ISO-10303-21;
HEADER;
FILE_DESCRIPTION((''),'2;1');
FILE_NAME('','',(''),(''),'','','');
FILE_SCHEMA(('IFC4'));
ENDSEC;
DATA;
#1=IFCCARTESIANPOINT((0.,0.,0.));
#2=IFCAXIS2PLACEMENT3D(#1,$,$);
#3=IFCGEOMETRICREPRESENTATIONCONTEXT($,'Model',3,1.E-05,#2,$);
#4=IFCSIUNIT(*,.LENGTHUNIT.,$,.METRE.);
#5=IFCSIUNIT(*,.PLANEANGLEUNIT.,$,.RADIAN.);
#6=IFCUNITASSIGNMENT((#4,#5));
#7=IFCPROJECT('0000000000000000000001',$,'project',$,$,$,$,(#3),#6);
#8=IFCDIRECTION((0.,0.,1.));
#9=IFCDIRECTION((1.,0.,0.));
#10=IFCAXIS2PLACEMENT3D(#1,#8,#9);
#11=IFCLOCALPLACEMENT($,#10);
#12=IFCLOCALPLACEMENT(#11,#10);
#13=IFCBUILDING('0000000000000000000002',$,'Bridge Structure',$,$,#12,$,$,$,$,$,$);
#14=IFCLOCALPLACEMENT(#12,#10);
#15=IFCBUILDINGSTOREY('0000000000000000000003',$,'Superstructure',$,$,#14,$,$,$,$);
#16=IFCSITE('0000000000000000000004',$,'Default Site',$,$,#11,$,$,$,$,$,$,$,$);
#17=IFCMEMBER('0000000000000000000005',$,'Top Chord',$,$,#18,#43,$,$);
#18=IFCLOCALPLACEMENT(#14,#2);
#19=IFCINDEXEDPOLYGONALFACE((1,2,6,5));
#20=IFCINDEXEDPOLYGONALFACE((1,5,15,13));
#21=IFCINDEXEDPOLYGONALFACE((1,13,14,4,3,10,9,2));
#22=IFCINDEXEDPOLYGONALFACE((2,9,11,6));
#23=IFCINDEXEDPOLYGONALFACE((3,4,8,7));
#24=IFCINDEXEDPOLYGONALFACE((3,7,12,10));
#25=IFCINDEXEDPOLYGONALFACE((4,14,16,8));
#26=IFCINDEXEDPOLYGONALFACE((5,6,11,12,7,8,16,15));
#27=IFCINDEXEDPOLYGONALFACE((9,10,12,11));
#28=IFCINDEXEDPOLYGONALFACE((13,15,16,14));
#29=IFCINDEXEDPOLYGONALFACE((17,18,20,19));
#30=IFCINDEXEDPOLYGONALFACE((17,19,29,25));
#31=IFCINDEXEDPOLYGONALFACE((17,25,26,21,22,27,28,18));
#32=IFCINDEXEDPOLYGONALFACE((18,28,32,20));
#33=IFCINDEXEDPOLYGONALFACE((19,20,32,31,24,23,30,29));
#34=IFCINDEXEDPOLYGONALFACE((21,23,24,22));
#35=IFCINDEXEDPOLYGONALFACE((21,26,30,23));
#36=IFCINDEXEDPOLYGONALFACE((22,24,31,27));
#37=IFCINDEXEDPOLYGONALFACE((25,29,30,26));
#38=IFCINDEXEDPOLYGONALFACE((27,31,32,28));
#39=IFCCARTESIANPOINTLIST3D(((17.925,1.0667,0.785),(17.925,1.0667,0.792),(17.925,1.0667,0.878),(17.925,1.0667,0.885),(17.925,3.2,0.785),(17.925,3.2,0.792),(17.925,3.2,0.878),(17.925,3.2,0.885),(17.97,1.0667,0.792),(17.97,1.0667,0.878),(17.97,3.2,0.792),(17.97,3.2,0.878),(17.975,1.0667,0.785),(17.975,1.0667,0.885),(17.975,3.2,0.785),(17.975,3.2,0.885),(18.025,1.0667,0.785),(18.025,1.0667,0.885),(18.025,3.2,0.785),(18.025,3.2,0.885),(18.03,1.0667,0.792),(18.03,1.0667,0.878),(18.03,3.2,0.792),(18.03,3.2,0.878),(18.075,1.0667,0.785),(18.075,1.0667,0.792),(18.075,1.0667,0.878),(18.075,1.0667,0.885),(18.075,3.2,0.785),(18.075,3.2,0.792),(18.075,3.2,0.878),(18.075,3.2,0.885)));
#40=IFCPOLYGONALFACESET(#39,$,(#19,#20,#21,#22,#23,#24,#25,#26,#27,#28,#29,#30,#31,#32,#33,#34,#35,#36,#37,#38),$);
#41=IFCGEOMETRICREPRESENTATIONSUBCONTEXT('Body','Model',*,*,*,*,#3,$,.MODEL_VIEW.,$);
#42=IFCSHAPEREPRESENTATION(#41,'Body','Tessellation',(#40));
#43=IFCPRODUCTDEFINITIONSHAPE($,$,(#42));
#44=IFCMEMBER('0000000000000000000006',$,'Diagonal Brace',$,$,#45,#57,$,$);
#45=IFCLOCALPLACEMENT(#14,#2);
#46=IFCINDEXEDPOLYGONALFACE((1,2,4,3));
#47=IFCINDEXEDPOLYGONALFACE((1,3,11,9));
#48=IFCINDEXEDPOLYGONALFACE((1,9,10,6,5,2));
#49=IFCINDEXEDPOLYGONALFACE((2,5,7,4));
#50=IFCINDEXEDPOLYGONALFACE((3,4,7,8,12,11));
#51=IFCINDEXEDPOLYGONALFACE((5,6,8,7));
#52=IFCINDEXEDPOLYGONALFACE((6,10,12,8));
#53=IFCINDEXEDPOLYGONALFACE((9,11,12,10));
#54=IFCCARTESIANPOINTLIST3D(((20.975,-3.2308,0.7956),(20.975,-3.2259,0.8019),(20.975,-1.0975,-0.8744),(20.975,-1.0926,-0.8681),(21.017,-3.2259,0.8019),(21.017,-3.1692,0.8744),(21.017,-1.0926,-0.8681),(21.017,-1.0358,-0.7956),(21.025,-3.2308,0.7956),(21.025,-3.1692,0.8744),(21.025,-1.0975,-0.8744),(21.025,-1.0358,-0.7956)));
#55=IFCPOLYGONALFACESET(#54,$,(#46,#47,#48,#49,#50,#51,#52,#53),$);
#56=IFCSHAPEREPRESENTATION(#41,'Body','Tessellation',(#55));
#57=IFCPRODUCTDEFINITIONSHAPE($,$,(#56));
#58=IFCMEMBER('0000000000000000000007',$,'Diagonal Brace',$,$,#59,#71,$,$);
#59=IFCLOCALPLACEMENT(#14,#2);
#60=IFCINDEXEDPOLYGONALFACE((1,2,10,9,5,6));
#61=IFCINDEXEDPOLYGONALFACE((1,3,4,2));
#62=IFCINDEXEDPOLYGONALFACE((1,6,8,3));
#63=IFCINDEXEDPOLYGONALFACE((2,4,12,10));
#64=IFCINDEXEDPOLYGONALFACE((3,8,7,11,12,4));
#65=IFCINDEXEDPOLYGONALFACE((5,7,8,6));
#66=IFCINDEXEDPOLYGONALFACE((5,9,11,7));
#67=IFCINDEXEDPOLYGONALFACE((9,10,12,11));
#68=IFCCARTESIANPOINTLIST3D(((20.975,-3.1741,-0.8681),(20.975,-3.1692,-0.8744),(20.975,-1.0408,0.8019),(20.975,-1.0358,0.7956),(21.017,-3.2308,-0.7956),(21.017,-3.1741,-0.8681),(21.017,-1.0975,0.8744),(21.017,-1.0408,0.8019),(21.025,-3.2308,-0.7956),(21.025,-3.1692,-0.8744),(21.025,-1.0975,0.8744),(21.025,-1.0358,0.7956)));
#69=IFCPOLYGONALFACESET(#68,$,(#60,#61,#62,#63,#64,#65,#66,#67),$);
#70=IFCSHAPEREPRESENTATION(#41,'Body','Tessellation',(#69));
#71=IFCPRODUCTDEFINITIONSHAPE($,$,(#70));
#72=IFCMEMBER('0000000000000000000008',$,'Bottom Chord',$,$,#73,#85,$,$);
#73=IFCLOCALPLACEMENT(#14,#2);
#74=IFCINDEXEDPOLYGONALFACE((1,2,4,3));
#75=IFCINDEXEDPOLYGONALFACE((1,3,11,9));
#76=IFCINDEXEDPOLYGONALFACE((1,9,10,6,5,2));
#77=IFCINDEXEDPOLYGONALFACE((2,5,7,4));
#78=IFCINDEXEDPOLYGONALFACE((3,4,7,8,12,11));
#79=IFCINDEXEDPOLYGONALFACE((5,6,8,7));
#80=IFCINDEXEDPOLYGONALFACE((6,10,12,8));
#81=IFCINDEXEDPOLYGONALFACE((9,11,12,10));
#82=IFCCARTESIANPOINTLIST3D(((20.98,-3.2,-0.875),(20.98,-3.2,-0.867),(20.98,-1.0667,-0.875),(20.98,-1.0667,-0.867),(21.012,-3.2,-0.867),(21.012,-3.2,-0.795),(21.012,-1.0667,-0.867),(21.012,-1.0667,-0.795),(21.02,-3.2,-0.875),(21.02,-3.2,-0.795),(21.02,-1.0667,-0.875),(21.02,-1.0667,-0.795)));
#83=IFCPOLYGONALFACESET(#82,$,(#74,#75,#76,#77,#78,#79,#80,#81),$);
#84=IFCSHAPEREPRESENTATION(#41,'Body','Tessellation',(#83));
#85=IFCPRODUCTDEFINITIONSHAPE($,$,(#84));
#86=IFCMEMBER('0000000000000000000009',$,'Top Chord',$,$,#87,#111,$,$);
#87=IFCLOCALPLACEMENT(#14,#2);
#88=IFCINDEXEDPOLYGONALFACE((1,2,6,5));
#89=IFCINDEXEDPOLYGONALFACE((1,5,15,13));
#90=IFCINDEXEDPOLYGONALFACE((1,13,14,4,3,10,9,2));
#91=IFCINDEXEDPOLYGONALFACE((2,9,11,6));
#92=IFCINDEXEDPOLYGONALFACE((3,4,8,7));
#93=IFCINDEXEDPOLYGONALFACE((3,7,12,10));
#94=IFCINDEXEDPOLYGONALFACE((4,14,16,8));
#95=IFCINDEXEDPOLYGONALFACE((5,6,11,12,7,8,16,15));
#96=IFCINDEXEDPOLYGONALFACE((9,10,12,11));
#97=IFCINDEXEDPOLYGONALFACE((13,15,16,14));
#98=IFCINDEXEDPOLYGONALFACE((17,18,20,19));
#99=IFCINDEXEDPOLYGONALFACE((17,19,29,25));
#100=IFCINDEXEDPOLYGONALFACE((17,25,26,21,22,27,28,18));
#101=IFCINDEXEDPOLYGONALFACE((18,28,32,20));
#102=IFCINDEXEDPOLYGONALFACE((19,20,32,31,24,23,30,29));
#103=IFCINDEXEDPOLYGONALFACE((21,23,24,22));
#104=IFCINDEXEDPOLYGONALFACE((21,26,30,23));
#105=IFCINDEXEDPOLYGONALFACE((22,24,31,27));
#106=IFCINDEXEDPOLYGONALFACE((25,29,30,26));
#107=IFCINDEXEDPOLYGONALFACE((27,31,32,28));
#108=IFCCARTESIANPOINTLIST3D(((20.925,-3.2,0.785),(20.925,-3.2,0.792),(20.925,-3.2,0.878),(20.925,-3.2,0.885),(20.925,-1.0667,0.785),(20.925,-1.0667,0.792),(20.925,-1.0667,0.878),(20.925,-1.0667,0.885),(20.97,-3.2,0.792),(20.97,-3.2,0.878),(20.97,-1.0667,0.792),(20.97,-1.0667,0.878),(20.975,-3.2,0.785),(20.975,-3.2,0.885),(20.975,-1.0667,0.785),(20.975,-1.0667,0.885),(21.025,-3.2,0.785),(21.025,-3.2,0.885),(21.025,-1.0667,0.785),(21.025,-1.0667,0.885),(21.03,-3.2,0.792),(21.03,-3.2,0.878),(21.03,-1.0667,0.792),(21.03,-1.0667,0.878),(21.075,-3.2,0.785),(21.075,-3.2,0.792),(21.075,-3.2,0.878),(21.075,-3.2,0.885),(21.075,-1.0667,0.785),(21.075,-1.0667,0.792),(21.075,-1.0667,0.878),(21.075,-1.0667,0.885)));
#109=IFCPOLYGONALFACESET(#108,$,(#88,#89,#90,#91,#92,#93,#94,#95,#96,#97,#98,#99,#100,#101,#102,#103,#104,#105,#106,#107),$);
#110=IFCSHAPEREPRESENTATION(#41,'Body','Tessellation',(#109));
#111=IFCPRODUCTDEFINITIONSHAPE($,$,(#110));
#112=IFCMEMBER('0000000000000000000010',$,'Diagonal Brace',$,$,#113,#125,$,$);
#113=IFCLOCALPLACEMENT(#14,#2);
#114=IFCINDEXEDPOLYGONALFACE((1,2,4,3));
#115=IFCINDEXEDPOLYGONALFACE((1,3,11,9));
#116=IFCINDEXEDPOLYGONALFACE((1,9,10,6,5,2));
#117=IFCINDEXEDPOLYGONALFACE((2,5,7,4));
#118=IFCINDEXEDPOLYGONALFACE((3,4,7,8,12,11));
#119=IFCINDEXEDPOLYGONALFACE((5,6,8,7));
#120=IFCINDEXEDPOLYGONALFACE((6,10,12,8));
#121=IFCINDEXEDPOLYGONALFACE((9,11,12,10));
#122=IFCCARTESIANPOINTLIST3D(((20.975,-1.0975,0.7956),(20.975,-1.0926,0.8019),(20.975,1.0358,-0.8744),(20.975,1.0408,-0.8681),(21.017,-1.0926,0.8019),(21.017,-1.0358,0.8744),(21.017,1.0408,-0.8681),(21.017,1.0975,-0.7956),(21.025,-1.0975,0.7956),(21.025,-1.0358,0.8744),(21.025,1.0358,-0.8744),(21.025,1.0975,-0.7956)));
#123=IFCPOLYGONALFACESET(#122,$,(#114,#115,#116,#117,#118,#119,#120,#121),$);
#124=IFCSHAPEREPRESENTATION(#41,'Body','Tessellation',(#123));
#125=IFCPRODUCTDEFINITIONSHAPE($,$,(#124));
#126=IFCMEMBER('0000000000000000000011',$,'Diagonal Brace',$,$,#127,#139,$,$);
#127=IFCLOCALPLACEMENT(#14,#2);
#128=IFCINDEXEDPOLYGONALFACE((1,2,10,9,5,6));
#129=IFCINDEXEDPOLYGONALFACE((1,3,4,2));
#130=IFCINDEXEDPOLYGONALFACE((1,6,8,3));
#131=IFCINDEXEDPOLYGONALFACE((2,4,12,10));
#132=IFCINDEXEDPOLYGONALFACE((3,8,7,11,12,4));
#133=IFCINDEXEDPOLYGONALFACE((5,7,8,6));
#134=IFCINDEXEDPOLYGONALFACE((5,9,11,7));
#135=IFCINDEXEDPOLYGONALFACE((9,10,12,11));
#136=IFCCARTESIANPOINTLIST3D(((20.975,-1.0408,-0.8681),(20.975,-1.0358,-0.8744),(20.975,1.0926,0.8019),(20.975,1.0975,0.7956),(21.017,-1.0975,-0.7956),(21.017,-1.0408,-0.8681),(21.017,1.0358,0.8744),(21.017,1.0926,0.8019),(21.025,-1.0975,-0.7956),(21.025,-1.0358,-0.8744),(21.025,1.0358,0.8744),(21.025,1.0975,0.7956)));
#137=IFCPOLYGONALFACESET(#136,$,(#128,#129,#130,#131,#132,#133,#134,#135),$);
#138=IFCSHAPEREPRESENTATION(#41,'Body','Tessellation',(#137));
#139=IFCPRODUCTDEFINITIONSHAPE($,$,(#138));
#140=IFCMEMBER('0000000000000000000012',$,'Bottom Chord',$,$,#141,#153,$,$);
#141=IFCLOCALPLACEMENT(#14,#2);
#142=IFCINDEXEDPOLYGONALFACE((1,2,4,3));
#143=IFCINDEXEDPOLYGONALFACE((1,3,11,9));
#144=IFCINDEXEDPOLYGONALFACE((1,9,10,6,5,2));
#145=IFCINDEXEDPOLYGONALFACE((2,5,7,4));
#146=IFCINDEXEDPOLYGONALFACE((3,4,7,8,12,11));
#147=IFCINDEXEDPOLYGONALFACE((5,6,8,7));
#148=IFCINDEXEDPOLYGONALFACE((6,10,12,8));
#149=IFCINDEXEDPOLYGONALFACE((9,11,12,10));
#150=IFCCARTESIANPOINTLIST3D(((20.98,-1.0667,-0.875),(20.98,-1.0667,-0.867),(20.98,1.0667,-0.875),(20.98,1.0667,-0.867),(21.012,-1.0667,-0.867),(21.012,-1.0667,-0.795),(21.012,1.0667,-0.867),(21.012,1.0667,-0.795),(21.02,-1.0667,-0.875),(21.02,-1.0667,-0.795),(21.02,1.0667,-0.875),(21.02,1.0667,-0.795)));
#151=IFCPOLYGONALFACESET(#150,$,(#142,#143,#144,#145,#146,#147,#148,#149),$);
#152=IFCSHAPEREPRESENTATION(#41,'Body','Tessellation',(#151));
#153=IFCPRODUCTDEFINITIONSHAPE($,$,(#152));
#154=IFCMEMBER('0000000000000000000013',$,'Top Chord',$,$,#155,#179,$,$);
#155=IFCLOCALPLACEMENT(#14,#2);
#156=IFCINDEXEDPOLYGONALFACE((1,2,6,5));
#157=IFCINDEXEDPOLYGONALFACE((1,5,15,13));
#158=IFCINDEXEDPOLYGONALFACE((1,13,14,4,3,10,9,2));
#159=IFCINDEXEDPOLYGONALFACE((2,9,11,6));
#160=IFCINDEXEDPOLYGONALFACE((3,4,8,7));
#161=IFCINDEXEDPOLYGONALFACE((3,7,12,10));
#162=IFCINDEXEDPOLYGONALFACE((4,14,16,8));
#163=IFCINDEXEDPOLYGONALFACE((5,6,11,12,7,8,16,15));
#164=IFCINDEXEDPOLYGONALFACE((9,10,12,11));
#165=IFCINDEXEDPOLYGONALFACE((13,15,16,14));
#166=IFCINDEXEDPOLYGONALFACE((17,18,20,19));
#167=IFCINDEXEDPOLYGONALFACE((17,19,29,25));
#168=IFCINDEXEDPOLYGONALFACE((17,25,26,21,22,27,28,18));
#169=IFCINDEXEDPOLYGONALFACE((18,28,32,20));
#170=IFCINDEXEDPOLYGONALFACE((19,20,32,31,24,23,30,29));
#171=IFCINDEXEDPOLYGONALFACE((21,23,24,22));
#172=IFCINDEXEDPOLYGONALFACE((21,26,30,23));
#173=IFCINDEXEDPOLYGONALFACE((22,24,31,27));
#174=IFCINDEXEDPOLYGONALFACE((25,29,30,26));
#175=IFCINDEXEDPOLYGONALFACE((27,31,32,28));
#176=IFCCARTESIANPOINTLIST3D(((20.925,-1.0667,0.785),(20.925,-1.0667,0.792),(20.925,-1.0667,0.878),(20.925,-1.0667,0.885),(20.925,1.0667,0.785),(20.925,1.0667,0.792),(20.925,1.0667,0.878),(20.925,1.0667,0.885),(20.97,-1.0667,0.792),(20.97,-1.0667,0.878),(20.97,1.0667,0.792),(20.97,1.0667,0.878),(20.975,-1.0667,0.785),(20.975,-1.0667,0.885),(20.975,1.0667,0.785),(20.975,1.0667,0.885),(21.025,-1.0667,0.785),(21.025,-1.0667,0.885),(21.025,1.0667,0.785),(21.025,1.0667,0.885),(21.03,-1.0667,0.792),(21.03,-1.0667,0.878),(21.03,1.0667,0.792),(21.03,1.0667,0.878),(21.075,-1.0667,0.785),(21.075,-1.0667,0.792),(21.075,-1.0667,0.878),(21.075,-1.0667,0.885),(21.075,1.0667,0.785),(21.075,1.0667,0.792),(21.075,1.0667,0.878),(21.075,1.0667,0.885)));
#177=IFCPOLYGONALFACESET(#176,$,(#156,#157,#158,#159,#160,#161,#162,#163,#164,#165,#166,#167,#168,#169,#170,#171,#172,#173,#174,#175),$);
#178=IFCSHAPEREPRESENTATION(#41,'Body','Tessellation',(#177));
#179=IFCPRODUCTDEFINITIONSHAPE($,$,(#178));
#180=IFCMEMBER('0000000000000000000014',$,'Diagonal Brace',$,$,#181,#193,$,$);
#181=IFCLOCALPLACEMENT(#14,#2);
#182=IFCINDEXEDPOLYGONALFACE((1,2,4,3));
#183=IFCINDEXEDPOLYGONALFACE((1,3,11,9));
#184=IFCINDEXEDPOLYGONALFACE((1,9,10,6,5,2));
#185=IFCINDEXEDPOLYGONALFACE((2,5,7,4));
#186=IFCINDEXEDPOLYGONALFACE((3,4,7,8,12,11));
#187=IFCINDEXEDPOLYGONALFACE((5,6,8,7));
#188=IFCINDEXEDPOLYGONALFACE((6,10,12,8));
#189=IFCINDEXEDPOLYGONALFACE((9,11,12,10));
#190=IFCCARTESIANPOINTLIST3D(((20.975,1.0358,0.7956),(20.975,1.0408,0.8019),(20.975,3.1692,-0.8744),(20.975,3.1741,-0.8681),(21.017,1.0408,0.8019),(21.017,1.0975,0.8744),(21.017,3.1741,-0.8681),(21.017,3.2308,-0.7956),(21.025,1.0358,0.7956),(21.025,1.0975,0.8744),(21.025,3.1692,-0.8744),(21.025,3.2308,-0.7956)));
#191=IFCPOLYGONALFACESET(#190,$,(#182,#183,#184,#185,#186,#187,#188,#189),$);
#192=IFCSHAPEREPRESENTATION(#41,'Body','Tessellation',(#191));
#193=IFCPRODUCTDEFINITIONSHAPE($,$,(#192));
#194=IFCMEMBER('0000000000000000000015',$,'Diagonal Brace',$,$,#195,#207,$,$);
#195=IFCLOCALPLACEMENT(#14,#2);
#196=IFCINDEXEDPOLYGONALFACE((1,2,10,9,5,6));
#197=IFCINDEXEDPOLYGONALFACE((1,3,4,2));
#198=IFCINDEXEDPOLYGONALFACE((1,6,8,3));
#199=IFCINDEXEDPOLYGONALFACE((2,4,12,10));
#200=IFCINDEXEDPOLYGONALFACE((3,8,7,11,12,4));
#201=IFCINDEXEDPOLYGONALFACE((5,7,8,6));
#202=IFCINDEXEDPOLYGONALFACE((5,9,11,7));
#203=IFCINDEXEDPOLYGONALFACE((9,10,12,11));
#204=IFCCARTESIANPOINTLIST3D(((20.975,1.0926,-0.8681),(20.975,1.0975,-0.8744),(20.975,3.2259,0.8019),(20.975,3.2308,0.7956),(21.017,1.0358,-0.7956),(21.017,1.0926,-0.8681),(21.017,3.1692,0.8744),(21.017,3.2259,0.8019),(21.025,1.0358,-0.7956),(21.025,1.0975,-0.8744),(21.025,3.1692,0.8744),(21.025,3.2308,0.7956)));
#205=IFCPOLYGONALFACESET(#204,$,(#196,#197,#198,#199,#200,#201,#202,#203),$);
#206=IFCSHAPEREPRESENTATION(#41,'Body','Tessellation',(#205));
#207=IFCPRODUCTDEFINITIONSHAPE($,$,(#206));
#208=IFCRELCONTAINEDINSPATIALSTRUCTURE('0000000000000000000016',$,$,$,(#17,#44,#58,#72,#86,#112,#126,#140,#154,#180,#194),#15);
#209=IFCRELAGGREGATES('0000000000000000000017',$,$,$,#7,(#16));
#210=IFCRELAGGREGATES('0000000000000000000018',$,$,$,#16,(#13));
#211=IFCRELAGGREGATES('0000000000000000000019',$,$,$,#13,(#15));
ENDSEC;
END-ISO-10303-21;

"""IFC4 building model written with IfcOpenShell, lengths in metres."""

from ifc_helpers import new_model, si_unit, frame, origin, origin_with_axes, origin_2d_with_axis, place, context, subcontext, project, spatial, polyline, l_section, outline, composite_profile, extrude, element, save


model = new_model("IFC4")

# Units and contexts
model_context = context("Model", 3, precision=1e-05, world=origin())
body_context = subcontext(model_context, "Body", "Model", "MODEL_VIEW")
ifc_project = project(units=[si_unit("LENGTHUNIT", "METRE"), si_unit("PLANEANGLEUNIT", "RADIAN")], contexts=[model_context])

# Site, building, storey
site_placement = place(None, origin_with_axes())
site = spatial("IfcSite", under=ifc_project, at=site_placement, Name="Default Site")
building_placement = place(site_placement, origin_with_axes())
building = spatial("IfcBuilding", under=site, at=building_placement, Name="Bridge Structure")
storey_placement = place(building_placement, origin_with_axes())
storey = spatial("IfcBuildingStorey", under=building, at=storey_placement, Name="Superstructure")

# Members
member_1_placement = place(storey_placement, frame((18.0, 1.0667, 0.835), z_axis=(0.0, 1.0, 0.0), x_axis=(-1.0, 0.0, 0.0)))
element("IfcMember", 1, at=member_1_placement, inside=storey, Name="Top Chord", context=body_context, shape_type="SweptSolid", body=[
    extrude(composite_profile([outline(polyline([(-0.025, -0.05), (-0.025, 0.05), (-0.075, 0.05), (-0.075, 0.043), (-0.03, 0.043), (-0.03, -0.043), (-0.075, -0.043), (-0.075, -0.05), (-0.025, -0.05)])), outline(polyline([(0.025, -0.05), (0.075, -0.05), (0.075, -0.043), (0.03, -0.043), (0.03, 0.043), (0.075, 0.043), (0.075, 0.05), (0.025, 0.05), (0.025, -0.05)]))]), origin_with_axes(), (0.0, 0.0, 1.0), 2.1333),
])
for number, where, z_axis, x_axis, name in (
    (2, (21.0, -3.2, 0.835), (0.0, 0.787427, -0.616408), (-1.0, 0.0, 0.0), "Diagonal Brace"),
    (3, (21.0, -3.2, -0.835), (0.0, 0.787427, 0.616408), (-1.0, 0.0, 0.0), "Diagonal Brace"),
):
    element("IfcMember", number, at=place(storey_placement, frame(where, z_axis=z_axis, x_axis=x_axis)), inside=storey, Name=name, context=body_context, shape_type="SweptSolid", body=[
        extrude(l_section(Depth=0.1, Width=0.05, Thickness=0.008, at=origin_2d_with_axis()), origin_with_axes(), (0.0, 0.0, 1.0), 2.7092),
    ])
member_2_placement = place(storey_placement, frame((21.0, -3.2, -0.835), z_axis=(0.0, 1.0, 0.0), x_axis=(-1.0, 0.0, 0.0)))
element("IfcMember", 4, at=member_2_placement, inside=storey, Name="Bottom Chord", context=body_context, shape_type="SweptSolid", body=[
    extrude(l_section(Depth=0.08, Width=0.04, Thickness=0.008, at=origin_2d_with_axis()), origin_with_axes(), (0.0, 0.0, 1.0), 2.1333),
])
member_3_placement = place(storey_placement, frame((21.0, -3.2, 0.835), z_axis=(0.0, 1.0, 0.0), x_axis=(-1.0, 0.0, 0.0)))
element("IfcMember", 5, at=member_3_placement, inside=storey, Name="Top Chord", context=body_context, shape_type="SweptSolid", body=[
    extrude(composite_profile([outline(polyline([(-0.025, -0.05), (-0.025, 0.05), (-0.075, 0.05), (-0.075, 0.043), (-0.03, 0.043), (-0.03, -0.043), (-0.075, -0.043), (-0.075, -0.05), (-0.025, -0.05)])), outline(polyline([(0.025, -0.05), (0.075, -0.05), (0.075, -0.043), (0.03, -0.043), (0.03, 0.043), (0.075, 0.043), (0.075, 0.05), (0.025, 0.05), (0.025, -0.05)]))]), origin_with_axes(), (0.0, 0.0, 1.0), 2.1333),
])
for number, where, z_axis, x_axis, name in (
    (6, (21.0, -1.0667, 0.835), (0.0, 0.787427, -0.616408), (-1.0, 0.0, 0.0), "Diagonal Brace"),
    (7, (21.0, -1.0667, -0.835), (0.0, 0.787427, 0.616408), (-1.0, 0.0, 0.0), "Diagonal Brace"),
):
    element("IfcMember", number, at=place(storey_placement, frame(where, z_axis=z_axis, x_axis=x_axis)), inside=storey, Name=name, context=body_context, shape_type="SweptSolid", body=[
        extrude(l_section(Depth=0.1, Width=0.05, Thickness=0.008, at=origin_2d_with_axis()), origin_with_axes(), (0.0, 0.0, 1.0), 2.7092),
    ])
member_4_placement = place(storey_placement, frame((21.0, -1.0667, -0.835), z_axis=(0.0, 1.0, 0.0), x_axis=(-1.0, 0.0, 0.0)))
element("IfcMember", 8, at=member_4_placement, inside=storey, Name="Bottom Chord", context=body_context, shape_type="SweptSolid", body=[
    extrude(l_section(Depth=0.08, Width=0.04, Thickness=0.008, at=origin_2d_with_axis()), origin_with_axes(), (0.0, 0.0, 1.0), 2.1333),
])
member_5_placement = place(storey_placement, frame((21.0, -1.0667, 0.835), z_axis=(0.0, 1.0, 0.0), x_axis=(-1.0, 0.0, 0.0)))
element("IfcMember", 9, at=member_5_placement, inside=storey, Name="Top Chord", context=body_context, shape_type="SweptSolid", body=[
    extrude(composite_profile([outline(polyline([(-0.025, -0.05), (-0.025, 0.05), (-0.075, 0.05), (-0.075, 0.043), (-0.03, 0.043), (-0.03, -0.043), (-0.075, -0.043), (-0.075, -0.05), (-0.025, -0.05)])), outline(polyline([(0.025, -0.05), (0.075, -0.05), (0.075, -0.043), (0.03, -0.043), (0.03, 0.043), (0.075, 0.043), (0.075, 0.05), (0.025, 0.05), (0.025, -0.05)]))]), origin_with_axes(), (0.0, 0.0, 1.0), 2.1333),
])
for number, where, z_axis, x_axis, name in (
    (10, (21.0, 1.0667, 0.835), (0.0, 0.787427, -0.616408), (-1.0, 0.0, 0.0), "Diagonal Brace"),
    (11, (21.0, 1.0667, -0.835), (0.0, 0.787427, 0.616408), (-1.0, 0.0, 0.0), "Diagonal Brace"),
):
    element("IfcMember", number, at=place(storey_placement, frame(where, z_axis=z_axis, x_axis=x_axis)), inside=storey, Name=name, context=body_context, shape_type="SweptSolid", body=[
        extrude(l_section(Depth=0.1, Width=0.05, Thickness=0.008, at=origin_2d_with_axis()), origin_with_axes(), (0.0, 0.0, 1.0), 2.7092),
    ])

save(model, "model.ifc")
